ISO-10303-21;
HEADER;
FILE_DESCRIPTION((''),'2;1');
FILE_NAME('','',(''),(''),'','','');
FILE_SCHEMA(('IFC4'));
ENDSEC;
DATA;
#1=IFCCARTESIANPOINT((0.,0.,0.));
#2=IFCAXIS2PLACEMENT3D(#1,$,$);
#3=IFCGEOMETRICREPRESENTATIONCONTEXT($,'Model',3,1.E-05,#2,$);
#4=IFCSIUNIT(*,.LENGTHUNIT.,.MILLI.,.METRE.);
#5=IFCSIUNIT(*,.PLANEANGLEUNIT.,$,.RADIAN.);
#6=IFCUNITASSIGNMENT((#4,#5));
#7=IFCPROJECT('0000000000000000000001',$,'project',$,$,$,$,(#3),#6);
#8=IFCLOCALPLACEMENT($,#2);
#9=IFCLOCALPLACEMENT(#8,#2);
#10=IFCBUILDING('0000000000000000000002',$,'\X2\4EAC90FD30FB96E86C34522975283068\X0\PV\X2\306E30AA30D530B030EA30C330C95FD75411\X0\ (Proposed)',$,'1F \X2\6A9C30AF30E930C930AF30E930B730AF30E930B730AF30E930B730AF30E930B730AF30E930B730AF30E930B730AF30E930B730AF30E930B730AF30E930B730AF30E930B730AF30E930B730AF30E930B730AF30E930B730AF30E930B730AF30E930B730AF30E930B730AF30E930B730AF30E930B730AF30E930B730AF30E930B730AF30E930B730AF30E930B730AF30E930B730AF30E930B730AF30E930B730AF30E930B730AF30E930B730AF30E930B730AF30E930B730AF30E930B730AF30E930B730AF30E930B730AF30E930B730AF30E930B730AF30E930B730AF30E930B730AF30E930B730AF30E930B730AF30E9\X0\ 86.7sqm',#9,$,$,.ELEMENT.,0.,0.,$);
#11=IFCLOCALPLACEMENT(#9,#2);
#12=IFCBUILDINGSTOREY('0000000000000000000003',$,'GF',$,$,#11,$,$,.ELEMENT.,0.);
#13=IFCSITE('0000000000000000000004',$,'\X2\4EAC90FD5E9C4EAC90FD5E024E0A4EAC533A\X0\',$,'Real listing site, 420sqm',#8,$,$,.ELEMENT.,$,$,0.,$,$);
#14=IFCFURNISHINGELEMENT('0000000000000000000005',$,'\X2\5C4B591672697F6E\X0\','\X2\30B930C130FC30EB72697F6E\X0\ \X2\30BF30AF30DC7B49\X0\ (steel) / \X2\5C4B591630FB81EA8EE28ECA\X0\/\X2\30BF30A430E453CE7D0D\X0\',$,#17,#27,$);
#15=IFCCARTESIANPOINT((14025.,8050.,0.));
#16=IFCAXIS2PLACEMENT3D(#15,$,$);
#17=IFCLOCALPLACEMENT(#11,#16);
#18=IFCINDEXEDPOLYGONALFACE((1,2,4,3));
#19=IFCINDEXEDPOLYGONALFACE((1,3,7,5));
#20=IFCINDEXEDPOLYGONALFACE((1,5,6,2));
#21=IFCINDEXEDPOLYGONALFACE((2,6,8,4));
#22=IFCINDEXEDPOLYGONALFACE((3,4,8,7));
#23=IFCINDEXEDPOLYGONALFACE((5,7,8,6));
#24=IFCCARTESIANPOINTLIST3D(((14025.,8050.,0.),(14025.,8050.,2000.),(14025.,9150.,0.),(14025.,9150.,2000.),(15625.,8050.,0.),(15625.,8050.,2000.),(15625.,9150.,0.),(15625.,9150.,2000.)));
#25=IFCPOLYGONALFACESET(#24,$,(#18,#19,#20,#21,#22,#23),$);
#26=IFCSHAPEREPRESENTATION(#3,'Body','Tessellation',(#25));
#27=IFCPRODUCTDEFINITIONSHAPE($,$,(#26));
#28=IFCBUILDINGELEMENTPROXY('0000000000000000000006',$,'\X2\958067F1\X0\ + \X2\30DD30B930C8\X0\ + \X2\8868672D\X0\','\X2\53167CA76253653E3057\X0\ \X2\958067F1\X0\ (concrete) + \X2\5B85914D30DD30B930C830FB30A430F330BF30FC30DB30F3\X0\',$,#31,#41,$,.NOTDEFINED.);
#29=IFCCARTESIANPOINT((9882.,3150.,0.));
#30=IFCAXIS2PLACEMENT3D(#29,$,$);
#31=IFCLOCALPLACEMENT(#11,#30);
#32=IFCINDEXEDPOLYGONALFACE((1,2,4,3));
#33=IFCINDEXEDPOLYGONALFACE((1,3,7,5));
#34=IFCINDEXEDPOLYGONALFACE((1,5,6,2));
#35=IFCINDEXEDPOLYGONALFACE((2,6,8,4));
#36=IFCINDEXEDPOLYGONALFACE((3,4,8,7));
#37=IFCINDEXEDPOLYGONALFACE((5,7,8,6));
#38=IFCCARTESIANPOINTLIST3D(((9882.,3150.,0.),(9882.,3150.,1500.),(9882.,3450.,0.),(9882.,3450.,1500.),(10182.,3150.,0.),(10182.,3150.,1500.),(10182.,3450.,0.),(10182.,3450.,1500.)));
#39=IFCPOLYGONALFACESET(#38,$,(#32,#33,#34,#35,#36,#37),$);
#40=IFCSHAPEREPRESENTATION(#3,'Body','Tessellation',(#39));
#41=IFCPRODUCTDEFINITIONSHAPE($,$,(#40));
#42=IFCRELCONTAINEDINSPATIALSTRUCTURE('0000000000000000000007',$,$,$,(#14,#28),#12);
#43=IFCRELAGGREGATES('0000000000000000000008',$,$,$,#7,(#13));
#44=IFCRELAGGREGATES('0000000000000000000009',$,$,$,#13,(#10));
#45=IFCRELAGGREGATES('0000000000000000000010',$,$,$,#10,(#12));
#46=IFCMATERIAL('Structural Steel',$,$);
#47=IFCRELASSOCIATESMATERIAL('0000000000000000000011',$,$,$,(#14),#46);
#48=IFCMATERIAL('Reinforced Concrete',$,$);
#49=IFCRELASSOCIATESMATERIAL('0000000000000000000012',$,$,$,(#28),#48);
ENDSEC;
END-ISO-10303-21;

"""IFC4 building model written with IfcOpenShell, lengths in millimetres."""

from ifc_helpers import new_model, si_unit, frame, frame_2d, origin, place, context, project, spatial, rectangle, extrude, material, element, save


model = new_model("IFC4")

# Units and contexts
model_context = context("Model", 3, precision=1e-05, world=origin())
ifc_project = project(units=[si_unit("LENGTHUNIT", "METRE", prefix="MILLI"), si_unit("PLANEANGLEUNIT", "RADIAN")], contexts=[model_context])

# Site, building, storey
site_placement = place(None, origin())
site = spatial("IfcSite", under=ifc_project, at=site_placement, Name="京都府京都市上京区", ObjectType="Real listing site, 420sqm", CompositionType="ELEMENT", RefElevation=0.0)
building_placement = place(site_placement, origin())
building = spatial("IfcBuilding", under=site, at=building_placement, Name="京都・雨水利用とPVのオフグリッド志向 (Proposed)", ObjectType="1F 檜クラドクラシクラシクラシクラシクラシクラシクラシクラシクラシクラシクラシクラシクラシクラシクラシクラシクラシクラシクラシクラシクラシクラシクラシクラシクラシクラシクラシクラシクラシクラシクラシクラシクラシクラシクラシクラシクラシクラシクラ 86.7sqm", CompositionType="ELEMENT", ElevationOfRefHeight=0.0, ElevationOfTerrain=0.0)
storey_placement = place(building_placement, origin())
storey = spatial("IfcBuildingStorey", under=building, at=storey_placement, Name="GF", CompositionType="ELEMENT", Elevation=0.0)

# Shared definitions
ifc_material_1 = material(Name="Reinforced Concrete")

# Shared definitions
ifc_material_2 = material(Name="Structural Steel")

# Furnishing element
furnishing_1_placement = place(storey_placement, frame((14025.0, 8050.0, 0.0)))
element("IfcFurnishingElement", 1, at=furnishing_1_placement, inside=storey, material=ifc_material_2, Name="屋外物置", Description="スチール物置 タクボ等 (steel) / 屋外・自転車/タイヤ収納", context=model_context, shape_type="SweptSolid", body=[
    extrude(rectangle(XDim=1600.0, YDim=1100.0, at=frame_2d((800.0, 550.0))), frame((14025.0, 8050.0, 0.0)), (0.0, 0.0, 1.0), 2000.0),
])

# Building element proxy
proxy_placement = place(storey_placement, frame((9882.0, 3150.0, 0.0)))
element("IfcBuildingElementProxy", 2, at=proxy_placement, inside=storey, material=ifc_material_1, Name="門柱 + ポスト + 表札", Description="化粧打放し 門柱 (concrete) + 宅配ポスト・インターホン", PredefinedType="NOTDEFINED", context=model_context, shape_type="SweptSolid", body=[
    extrude(rectangle(XDim=300.0, YDim=300.0, at=frame_2d((150.0, 150.0))), frame((9882.0, 3150.0, 0.0)), (0.0, 0.0, 1.0), 1500.0),
])

save(model, "model.ifc")
